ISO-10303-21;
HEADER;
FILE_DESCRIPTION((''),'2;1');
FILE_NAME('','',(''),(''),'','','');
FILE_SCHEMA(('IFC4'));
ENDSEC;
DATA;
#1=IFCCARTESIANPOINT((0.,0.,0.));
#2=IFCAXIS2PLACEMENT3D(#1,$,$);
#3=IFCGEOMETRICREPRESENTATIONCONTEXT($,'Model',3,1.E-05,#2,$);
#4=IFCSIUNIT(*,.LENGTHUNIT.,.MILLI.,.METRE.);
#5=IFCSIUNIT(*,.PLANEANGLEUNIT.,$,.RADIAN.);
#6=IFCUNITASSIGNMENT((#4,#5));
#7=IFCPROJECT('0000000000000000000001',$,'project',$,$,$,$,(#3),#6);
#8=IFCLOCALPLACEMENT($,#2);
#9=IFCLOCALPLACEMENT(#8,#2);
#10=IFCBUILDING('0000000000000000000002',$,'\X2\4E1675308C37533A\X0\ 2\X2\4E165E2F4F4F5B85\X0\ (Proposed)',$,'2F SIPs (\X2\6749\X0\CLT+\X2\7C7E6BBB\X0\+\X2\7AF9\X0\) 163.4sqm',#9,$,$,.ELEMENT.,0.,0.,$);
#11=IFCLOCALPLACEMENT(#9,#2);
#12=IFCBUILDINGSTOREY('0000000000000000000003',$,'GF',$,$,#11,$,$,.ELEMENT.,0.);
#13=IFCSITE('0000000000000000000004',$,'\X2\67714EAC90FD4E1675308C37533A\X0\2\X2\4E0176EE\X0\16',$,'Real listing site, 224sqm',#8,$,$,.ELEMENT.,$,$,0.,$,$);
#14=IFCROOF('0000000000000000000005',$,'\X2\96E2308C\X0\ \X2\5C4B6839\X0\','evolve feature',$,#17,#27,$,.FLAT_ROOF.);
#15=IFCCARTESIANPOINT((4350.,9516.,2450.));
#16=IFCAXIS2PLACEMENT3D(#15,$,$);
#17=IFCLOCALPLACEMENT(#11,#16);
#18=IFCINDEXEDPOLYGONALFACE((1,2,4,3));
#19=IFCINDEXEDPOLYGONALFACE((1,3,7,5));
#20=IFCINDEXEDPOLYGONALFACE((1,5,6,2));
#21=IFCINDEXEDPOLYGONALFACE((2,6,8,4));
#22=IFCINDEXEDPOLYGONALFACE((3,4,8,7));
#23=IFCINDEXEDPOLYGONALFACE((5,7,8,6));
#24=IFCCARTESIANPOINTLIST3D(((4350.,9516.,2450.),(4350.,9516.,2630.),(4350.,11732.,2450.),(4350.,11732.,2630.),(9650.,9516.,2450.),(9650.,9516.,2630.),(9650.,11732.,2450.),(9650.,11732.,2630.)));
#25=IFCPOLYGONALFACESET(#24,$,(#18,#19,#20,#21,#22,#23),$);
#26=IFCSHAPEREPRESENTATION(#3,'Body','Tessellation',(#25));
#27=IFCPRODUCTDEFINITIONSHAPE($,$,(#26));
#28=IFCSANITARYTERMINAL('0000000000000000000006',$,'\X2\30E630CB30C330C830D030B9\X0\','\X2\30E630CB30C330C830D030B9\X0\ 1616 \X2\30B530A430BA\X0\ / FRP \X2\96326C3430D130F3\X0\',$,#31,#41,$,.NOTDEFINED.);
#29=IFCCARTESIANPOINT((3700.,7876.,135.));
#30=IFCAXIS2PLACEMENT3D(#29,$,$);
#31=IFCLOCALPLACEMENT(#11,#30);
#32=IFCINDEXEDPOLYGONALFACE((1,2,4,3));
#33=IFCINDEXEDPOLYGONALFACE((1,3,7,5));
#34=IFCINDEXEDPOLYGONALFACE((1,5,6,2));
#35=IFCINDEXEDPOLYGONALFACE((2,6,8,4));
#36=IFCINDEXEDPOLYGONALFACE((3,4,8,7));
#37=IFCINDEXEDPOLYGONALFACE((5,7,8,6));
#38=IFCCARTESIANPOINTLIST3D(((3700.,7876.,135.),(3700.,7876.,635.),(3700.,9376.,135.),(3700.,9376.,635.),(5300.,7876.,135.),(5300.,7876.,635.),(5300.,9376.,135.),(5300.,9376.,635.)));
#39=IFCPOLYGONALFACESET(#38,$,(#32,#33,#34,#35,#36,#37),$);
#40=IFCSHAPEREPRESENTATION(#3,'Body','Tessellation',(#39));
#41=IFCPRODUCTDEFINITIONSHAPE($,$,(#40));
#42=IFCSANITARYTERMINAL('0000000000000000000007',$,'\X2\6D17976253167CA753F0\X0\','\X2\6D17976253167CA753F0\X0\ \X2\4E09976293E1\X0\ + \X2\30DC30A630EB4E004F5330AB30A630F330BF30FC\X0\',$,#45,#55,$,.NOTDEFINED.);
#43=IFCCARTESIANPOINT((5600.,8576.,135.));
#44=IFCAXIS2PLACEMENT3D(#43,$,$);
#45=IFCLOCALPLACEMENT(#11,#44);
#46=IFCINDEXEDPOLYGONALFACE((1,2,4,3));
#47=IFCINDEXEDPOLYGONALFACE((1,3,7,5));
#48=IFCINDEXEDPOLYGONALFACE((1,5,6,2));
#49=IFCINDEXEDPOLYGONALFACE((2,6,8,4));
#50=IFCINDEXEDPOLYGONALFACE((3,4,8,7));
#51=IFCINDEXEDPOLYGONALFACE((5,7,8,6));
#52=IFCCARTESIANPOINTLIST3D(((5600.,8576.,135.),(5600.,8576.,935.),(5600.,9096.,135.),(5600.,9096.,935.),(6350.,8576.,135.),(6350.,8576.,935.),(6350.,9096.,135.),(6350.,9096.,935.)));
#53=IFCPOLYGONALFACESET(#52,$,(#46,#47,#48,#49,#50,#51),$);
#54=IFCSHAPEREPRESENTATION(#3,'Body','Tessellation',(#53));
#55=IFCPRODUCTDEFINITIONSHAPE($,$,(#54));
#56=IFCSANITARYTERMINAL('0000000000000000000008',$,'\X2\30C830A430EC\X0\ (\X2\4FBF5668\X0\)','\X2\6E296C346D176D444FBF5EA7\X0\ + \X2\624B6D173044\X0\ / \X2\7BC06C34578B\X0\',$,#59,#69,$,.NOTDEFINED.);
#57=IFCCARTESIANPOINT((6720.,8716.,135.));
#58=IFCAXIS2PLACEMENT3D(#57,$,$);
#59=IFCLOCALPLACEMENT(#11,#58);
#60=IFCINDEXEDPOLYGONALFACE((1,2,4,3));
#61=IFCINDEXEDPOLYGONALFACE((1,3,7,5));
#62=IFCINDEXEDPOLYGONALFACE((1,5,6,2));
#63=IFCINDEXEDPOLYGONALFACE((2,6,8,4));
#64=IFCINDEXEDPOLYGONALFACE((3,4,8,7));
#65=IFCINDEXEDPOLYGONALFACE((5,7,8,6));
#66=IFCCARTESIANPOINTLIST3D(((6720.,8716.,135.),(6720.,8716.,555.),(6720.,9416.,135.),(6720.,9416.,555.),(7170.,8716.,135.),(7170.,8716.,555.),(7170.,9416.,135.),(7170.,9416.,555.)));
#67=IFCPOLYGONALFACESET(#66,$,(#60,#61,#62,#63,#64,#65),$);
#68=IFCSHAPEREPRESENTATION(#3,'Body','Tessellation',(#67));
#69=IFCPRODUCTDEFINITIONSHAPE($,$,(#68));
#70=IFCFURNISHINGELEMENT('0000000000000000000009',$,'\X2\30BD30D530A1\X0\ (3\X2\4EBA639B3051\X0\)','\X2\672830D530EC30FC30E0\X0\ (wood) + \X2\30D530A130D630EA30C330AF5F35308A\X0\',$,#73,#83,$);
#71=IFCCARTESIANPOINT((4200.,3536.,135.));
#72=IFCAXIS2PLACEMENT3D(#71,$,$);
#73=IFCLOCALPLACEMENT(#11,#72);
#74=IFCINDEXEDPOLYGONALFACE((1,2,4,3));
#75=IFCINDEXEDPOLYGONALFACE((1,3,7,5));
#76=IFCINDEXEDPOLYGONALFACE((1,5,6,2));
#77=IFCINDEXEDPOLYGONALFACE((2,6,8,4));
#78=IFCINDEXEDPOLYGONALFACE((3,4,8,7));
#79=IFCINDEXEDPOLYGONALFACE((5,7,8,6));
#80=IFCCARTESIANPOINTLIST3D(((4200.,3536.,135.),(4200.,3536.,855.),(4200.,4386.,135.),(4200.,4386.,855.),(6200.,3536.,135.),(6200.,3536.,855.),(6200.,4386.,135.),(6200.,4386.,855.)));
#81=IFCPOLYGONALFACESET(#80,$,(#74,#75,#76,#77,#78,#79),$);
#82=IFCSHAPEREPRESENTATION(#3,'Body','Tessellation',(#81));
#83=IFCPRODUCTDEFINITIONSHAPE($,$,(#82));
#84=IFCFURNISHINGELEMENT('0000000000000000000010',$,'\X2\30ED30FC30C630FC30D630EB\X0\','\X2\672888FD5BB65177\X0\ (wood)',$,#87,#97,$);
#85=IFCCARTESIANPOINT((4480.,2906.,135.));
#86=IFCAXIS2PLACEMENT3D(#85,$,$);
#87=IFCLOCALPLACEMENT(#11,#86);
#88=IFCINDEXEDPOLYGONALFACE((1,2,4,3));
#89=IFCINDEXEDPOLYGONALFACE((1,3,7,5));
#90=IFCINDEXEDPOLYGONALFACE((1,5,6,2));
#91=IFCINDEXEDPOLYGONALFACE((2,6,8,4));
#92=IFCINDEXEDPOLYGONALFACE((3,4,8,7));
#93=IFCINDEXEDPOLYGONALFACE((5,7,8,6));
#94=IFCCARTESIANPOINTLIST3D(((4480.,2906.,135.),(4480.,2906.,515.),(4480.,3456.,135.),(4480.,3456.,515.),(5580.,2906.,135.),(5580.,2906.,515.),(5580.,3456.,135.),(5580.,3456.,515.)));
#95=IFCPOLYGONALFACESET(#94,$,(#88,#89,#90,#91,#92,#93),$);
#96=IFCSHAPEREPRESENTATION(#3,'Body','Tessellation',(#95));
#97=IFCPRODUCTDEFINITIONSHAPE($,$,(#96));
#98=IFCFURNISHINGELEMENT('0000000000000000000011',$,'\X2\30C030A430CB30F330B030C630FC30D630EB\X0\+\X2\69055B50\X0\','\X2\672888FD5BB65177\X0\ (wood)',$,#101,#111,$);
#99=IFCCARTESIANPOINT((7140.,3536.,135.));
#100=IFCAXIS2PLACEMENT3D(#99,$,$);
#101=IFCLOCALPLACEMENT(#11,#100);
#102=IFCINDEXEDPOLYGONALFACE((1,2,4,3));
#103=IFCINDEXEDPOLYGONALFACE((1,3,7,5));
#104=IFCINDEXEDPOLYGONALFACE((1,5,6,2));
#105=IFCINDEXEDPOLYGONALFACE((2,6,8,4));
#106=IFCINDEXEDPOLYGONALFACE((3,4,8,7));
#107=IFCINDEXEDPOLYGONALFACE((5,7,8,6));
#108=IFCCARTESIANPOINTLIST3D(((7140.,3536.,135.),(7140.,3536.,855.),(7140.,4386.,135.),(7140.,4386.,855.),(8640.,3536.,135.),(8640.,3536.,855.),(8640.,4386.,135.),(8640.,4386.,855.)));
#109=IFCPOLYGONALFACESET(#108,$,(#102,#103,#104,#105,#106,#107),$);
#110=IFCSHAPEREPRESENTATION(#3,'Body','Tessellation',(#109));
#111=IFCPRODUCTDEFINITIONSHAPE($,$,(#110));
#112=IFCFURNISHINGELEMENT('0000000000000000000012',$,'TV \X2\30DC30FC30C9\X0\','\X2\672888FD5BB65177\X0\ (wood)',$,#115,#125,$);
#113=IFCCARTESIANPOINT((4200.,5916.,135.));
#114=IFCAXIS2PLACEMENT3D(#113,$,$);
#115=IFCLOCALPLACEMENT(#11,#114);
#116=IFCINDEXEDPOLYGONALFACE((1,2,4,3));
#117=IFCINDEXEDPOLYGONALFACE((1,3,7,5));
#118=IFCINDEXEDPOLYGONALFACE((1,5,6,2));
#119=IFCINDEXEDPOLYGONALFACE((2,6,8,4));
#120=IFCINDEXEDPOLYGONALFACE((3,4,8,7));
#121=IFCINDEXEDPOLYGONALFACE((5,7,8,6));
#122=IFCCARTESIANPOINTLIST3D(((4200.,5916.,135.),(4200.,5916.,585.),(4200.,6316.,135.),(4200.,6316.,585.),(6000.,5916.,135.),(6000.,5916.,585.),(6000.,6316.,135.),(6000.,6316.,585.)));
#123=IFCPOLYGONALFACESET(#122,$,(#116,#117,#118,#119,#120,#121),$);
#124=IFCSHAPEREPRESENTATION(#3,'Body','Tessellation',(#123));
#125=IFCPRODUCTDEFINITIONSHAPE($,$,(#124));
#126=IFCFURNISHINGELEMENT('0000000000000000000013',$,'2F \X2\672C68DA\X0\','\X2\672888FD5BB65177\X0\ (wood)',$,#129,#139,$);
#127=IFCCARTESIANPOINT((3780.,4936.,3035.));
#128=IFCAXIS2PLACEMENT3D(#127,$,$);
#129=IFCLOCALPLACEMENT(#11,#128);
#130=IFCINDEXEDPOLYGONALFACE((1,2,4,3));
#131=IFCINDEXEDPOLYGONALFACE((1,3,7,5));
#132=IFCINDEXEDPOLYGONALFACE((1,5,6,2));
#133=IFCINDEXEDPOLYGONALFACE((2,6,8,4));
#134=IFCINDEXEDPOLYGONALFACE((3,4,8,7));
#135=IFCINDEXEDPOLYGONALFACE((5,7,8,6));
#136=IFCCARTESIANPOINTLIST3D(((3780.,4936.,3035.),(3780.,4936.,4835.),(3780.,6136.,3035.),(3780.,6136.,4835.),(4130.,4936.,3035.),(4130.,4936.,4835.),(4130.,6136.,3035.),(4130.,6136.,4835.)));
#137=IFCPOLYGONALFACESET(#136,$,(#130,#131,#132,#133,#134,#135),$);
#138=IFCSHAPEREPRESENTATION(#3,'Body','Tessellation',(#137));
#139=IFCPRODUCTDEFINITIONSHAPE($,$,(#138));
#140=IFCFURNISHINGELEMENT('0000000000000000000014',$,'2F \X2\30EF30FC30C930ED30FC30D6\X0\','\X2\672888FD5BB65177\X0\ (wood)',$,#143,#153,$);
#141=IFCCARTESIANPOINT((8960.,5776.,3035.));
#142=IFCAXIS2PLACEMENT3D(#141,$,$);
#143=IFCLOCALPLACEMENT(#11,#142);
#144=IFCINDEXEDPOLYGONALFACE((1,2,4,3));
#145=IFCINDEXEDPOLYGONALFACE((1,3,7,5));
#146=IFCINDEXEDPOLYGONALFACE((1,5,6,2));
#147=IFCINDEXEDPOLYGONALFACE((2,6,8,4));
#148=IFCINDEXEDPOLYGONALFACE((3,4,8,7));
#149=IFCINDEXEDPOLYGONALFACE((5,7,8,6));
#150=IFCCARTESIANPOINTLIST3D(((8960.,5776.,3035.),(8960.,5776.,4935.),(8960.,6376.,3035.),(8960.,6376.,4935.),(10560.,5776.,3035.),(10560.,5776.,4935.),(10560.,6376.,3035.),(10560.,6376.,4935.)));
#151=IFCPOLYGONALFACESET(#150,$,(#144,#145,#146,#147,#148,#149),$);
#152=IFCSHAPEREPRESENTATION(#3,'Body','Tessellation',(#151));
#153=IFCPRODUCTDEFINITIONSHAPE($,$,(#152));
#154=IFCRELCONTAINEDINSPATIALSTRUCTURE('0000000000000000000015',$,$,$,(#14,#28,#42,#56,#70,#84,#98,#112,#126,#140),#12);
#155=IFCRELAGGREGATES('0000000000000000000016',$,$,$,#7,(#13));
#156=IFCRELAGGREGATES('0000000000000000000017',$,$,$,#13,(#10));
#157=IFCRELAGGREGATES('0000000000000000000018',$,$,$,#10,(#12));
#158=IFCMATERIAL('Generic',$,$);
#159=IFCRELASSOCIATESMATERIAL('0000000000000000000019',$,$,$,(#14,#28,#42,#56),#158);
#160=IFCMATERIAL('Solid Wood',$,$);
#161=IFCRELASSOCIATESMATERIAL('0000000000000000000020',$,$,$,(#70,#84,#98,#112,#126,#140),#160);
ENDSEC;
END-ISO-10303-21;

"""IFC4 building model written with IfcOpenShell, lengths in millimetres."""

from ifc_helpers import new_model, si_unit, frame, frame_2d, origin, place, context, project, spatial, rectangle, extrude, material, element, save


model = new_model("IFC4")

# Units and contexts
model_context = context("Model", 3, precision=1e-05, world=origin())
ifc_project = project(units=[si_unit("LENGTHUNIT", "METRE", prefix="MILLI"), si_unit("PLANEANGLEUNIT", "RADIAN")], contexts=[model_context])

# Site, building, storey
site_placement = place(None, origin())
site = spatial("IfcSite", under=ifc_project, at=site_placement, Name="東京都世田谷区2丁目16", ObjectType="Real listing site, 224sqm", CompositionType="ELEMENT", RefElevation=0.0)
building_placement = place(site_placement, origin())
building = spatial("IfcBuilding", under=site, at=building_placement, Name="世田谷区 2世帯住宅 (Proposed)", ObjectType="2F SIPs (杉CLT+籾殻+竹) 163.4sqm", CompositionType="ELEMENT", ElevationOfRefHeight=0.0, ElevationOfTerrain=0.0)
storey_placement = place(building_placement, origin())
storey = spatial("IfcBuildingStorey", under=building, at=storey_placement, Name="GF", CompositionType="ELEMENT", Elevation=0.0)

# Shared definitions
ifc_material_1 = material(Name="Generic")

# Shared definitions
ifc_material_2 = material(Name="Solid Wood")

# Roof
roof_placement = place(storey_placement, frame((4350.0, 9516.0, 2450.0)))
element("IfcRoof", 1, at=roof_placement, inside=storey, material=ifc_material_1, Name="離れ 屋根", Description="evolve feature", PredefinedType="FLAT_ROOF", context=model_context, shape_type="SweptSolid", body=[
    extrude(rectangle(XDim=5300.0, YDim=2216.0, at=frame_2d((2650.0, 1108.0))), frame((4350.0, 9516.0, 2450.0)), (0.0, 0.0, 1.0), 180.0),
])

# Sanitary terminals
sanitary_terminal_1_placement = place(storey_placement, frame((3700.0, 7876.0, 135.0)))
element("IfcSanitaryTerminal", 2, at=sanitary_terminal_1_placement, inside=storey, material=ifc_material_1, Name="ユニットバス", Description="ユニットバス 1616 サイズ / FRP 防水パン", PredefinedType="NOTDEFINED", context=model_context, shape_type="SweptSolid", body=[
    extrude(rectangle(XDim=1600.0, YDim=1500.0, at=frame_2d((800.0, 750.0))), frame((3700.0, 7876.0, 135.0)), (0.0, 0.0, 1.0), 500.0),
])
sanitary_terminal_2_placement = place(storey_placement, frame((5600.0, 8576.0, 135.0)))
element("IfcSanitaryTerminal", 3, at=sanitary_terminal_2_placement, inside=storey, material=ifc_material_1, Name="洗面化粧台", Description="洗面化粧台 三面鏡 + ボウル一体カウンター", PredefinedType="NOTDEFINED", context=model_context, shape_type="SweptSolid", body=[
    extrude(rectangle(XDim=750.0, YDim=520.0, at=frame_2d((375.0, 260.0))), frame((5600.0, 8576.0, 135.0)), (0.0, 0.0, 1.0), 800.0),
])
sanitary_terminal_3_placement = place(storey_placement, frame((6720.0, 8716.0, 135.0)))
element("IfcSanitaryTerminal", 4, at=sanitary_terminal_3_placement, inside=storey, material=ifc_material_1, Name="トイレ (便器)", Description="温水洗浄便座 + 手洗い / 節水型", PredefinedType="NOTDEFINED", context=model_context, shape_type="SweptSolid", body=[
    extrude(rectangle(XDim=450.0, YDim=700.0, at=frame_2d((225.0, 350.0))), frame((6720.0, 8716.0, 135.0)), (0.0, 0.0, 1.0), 420.0),
])

# Furnishing elements
furnishing_1_placement = place(storey_placement, frame((4200.0, 3536.0, 135.0)))
element("IfcFurnishingElement", 5, at=furnishing_1_placement, inside=storey, material=ifc_material_2, Name="ソファ (3人掛け)", Description="木フレーム (wood) + ファブリック張り", context=model_context, shape_type="SweptSolid", body=[
    extrude(rectangle(XDim=2000.0, YDim=850.0, at=frame_2d((1000.0, 425.0))), frame((4200.0, 3536.0, 135.0)), (0.0, 0.0, 1.0), 720.0),
])
furnishing_2_placement = place(storey_placement, frame((4480.0, 2906.0, 135.0)))
element("IfcFurnishingElement", 6, at=furnishing_2_placement, inside=storey, material=ifc_material_2, Name="ローテーブル", Description="木製家具 (wood)", context=model_context, shape_type="SweptSolid", body=[
    extrude(rectangle(XDim=1100.0, YDim=550.0, at=frame_2d((550.0, 275.0))), frame((4480.0, 2906.0, 135.0)), (0.0, 0.0, 1.0), 380.0),
])
furnishing_3_placement = place(storey_placement, frame((7140.0, 3536.0, 135.0)))
element("IfcFurnishingElement", 7, at=furnishing_3_placement, inside=storey, material=ifc_material_2, Name="ダイニングテーブル+椅子", Description="木製家具 (wood)", context=model_context, shape_type="SweptSolid", body=[
    extrude(rectangle(XDim=1500.0, YDim=850.0, at=frame_2d((750.0, 425.0))), frame((7140.0, 3536.0, 135.0)), (0.0, 0.0, 1.0), 720.0),
])
furnishing_4_placement = place(storey_placement, frame((4200.0, 5916.0, 135.0)))
element("IfcFurnishingElement", 8, at=furnishing_4_placement, inside=storey, material=ifc_material_2, Name="TV ボード", Description="木製家具 (wood)", context=model_context, shape_type="SweptSolid", body=[
    extrude(rectangle(XDim=1800.0, YDim=400.0, at=frame_2d((900.0, 200.0))), frame((4200.0, 5916.0, 135.0)), (0.0, 0.0, 1.0), 450.0),
])
furnishing_5_placement = place(storey_placement, frame((3780.0, 4936.0, 3035.0)))
element("IfcFurnishingElement", 9, at=furnishing_5_placement, inside=storey, material=ifc_material_2, Name="2F 本棚", Description="木製家具 (wood)", context=model_context, shape_type="SweptSolid", body=[
    extrude(rectangle(XDim=350.0, YDim=1200.0, at=frame_2d((175.0, 600.0))), frame((3780.0, 4936.0, 3035.0)), (0.0, 0.0, 1.0), 1800.0),
])
furnishing_6_placement = place(storey_placement, frame((8960.0, 5776.0, 3035.0)))
element("IfcFurnishingElement", 10, at=furnishing_6_placement, inside=storey, material=ifc_material_2, Name="2F ワードローブ", Description="木製家具 (wood)", context=model_context, shape_type="SweptSolid", body=[
    extrude(rectangle(XDim=1600.0, YDim=600.0, at=frame_2d((800.0, 300.0))), frame((8960.0, 5776.0, 3035.0)), (0.0, 0.0, 1.0), 1900.0),
])

save(model, "model.ifc")
